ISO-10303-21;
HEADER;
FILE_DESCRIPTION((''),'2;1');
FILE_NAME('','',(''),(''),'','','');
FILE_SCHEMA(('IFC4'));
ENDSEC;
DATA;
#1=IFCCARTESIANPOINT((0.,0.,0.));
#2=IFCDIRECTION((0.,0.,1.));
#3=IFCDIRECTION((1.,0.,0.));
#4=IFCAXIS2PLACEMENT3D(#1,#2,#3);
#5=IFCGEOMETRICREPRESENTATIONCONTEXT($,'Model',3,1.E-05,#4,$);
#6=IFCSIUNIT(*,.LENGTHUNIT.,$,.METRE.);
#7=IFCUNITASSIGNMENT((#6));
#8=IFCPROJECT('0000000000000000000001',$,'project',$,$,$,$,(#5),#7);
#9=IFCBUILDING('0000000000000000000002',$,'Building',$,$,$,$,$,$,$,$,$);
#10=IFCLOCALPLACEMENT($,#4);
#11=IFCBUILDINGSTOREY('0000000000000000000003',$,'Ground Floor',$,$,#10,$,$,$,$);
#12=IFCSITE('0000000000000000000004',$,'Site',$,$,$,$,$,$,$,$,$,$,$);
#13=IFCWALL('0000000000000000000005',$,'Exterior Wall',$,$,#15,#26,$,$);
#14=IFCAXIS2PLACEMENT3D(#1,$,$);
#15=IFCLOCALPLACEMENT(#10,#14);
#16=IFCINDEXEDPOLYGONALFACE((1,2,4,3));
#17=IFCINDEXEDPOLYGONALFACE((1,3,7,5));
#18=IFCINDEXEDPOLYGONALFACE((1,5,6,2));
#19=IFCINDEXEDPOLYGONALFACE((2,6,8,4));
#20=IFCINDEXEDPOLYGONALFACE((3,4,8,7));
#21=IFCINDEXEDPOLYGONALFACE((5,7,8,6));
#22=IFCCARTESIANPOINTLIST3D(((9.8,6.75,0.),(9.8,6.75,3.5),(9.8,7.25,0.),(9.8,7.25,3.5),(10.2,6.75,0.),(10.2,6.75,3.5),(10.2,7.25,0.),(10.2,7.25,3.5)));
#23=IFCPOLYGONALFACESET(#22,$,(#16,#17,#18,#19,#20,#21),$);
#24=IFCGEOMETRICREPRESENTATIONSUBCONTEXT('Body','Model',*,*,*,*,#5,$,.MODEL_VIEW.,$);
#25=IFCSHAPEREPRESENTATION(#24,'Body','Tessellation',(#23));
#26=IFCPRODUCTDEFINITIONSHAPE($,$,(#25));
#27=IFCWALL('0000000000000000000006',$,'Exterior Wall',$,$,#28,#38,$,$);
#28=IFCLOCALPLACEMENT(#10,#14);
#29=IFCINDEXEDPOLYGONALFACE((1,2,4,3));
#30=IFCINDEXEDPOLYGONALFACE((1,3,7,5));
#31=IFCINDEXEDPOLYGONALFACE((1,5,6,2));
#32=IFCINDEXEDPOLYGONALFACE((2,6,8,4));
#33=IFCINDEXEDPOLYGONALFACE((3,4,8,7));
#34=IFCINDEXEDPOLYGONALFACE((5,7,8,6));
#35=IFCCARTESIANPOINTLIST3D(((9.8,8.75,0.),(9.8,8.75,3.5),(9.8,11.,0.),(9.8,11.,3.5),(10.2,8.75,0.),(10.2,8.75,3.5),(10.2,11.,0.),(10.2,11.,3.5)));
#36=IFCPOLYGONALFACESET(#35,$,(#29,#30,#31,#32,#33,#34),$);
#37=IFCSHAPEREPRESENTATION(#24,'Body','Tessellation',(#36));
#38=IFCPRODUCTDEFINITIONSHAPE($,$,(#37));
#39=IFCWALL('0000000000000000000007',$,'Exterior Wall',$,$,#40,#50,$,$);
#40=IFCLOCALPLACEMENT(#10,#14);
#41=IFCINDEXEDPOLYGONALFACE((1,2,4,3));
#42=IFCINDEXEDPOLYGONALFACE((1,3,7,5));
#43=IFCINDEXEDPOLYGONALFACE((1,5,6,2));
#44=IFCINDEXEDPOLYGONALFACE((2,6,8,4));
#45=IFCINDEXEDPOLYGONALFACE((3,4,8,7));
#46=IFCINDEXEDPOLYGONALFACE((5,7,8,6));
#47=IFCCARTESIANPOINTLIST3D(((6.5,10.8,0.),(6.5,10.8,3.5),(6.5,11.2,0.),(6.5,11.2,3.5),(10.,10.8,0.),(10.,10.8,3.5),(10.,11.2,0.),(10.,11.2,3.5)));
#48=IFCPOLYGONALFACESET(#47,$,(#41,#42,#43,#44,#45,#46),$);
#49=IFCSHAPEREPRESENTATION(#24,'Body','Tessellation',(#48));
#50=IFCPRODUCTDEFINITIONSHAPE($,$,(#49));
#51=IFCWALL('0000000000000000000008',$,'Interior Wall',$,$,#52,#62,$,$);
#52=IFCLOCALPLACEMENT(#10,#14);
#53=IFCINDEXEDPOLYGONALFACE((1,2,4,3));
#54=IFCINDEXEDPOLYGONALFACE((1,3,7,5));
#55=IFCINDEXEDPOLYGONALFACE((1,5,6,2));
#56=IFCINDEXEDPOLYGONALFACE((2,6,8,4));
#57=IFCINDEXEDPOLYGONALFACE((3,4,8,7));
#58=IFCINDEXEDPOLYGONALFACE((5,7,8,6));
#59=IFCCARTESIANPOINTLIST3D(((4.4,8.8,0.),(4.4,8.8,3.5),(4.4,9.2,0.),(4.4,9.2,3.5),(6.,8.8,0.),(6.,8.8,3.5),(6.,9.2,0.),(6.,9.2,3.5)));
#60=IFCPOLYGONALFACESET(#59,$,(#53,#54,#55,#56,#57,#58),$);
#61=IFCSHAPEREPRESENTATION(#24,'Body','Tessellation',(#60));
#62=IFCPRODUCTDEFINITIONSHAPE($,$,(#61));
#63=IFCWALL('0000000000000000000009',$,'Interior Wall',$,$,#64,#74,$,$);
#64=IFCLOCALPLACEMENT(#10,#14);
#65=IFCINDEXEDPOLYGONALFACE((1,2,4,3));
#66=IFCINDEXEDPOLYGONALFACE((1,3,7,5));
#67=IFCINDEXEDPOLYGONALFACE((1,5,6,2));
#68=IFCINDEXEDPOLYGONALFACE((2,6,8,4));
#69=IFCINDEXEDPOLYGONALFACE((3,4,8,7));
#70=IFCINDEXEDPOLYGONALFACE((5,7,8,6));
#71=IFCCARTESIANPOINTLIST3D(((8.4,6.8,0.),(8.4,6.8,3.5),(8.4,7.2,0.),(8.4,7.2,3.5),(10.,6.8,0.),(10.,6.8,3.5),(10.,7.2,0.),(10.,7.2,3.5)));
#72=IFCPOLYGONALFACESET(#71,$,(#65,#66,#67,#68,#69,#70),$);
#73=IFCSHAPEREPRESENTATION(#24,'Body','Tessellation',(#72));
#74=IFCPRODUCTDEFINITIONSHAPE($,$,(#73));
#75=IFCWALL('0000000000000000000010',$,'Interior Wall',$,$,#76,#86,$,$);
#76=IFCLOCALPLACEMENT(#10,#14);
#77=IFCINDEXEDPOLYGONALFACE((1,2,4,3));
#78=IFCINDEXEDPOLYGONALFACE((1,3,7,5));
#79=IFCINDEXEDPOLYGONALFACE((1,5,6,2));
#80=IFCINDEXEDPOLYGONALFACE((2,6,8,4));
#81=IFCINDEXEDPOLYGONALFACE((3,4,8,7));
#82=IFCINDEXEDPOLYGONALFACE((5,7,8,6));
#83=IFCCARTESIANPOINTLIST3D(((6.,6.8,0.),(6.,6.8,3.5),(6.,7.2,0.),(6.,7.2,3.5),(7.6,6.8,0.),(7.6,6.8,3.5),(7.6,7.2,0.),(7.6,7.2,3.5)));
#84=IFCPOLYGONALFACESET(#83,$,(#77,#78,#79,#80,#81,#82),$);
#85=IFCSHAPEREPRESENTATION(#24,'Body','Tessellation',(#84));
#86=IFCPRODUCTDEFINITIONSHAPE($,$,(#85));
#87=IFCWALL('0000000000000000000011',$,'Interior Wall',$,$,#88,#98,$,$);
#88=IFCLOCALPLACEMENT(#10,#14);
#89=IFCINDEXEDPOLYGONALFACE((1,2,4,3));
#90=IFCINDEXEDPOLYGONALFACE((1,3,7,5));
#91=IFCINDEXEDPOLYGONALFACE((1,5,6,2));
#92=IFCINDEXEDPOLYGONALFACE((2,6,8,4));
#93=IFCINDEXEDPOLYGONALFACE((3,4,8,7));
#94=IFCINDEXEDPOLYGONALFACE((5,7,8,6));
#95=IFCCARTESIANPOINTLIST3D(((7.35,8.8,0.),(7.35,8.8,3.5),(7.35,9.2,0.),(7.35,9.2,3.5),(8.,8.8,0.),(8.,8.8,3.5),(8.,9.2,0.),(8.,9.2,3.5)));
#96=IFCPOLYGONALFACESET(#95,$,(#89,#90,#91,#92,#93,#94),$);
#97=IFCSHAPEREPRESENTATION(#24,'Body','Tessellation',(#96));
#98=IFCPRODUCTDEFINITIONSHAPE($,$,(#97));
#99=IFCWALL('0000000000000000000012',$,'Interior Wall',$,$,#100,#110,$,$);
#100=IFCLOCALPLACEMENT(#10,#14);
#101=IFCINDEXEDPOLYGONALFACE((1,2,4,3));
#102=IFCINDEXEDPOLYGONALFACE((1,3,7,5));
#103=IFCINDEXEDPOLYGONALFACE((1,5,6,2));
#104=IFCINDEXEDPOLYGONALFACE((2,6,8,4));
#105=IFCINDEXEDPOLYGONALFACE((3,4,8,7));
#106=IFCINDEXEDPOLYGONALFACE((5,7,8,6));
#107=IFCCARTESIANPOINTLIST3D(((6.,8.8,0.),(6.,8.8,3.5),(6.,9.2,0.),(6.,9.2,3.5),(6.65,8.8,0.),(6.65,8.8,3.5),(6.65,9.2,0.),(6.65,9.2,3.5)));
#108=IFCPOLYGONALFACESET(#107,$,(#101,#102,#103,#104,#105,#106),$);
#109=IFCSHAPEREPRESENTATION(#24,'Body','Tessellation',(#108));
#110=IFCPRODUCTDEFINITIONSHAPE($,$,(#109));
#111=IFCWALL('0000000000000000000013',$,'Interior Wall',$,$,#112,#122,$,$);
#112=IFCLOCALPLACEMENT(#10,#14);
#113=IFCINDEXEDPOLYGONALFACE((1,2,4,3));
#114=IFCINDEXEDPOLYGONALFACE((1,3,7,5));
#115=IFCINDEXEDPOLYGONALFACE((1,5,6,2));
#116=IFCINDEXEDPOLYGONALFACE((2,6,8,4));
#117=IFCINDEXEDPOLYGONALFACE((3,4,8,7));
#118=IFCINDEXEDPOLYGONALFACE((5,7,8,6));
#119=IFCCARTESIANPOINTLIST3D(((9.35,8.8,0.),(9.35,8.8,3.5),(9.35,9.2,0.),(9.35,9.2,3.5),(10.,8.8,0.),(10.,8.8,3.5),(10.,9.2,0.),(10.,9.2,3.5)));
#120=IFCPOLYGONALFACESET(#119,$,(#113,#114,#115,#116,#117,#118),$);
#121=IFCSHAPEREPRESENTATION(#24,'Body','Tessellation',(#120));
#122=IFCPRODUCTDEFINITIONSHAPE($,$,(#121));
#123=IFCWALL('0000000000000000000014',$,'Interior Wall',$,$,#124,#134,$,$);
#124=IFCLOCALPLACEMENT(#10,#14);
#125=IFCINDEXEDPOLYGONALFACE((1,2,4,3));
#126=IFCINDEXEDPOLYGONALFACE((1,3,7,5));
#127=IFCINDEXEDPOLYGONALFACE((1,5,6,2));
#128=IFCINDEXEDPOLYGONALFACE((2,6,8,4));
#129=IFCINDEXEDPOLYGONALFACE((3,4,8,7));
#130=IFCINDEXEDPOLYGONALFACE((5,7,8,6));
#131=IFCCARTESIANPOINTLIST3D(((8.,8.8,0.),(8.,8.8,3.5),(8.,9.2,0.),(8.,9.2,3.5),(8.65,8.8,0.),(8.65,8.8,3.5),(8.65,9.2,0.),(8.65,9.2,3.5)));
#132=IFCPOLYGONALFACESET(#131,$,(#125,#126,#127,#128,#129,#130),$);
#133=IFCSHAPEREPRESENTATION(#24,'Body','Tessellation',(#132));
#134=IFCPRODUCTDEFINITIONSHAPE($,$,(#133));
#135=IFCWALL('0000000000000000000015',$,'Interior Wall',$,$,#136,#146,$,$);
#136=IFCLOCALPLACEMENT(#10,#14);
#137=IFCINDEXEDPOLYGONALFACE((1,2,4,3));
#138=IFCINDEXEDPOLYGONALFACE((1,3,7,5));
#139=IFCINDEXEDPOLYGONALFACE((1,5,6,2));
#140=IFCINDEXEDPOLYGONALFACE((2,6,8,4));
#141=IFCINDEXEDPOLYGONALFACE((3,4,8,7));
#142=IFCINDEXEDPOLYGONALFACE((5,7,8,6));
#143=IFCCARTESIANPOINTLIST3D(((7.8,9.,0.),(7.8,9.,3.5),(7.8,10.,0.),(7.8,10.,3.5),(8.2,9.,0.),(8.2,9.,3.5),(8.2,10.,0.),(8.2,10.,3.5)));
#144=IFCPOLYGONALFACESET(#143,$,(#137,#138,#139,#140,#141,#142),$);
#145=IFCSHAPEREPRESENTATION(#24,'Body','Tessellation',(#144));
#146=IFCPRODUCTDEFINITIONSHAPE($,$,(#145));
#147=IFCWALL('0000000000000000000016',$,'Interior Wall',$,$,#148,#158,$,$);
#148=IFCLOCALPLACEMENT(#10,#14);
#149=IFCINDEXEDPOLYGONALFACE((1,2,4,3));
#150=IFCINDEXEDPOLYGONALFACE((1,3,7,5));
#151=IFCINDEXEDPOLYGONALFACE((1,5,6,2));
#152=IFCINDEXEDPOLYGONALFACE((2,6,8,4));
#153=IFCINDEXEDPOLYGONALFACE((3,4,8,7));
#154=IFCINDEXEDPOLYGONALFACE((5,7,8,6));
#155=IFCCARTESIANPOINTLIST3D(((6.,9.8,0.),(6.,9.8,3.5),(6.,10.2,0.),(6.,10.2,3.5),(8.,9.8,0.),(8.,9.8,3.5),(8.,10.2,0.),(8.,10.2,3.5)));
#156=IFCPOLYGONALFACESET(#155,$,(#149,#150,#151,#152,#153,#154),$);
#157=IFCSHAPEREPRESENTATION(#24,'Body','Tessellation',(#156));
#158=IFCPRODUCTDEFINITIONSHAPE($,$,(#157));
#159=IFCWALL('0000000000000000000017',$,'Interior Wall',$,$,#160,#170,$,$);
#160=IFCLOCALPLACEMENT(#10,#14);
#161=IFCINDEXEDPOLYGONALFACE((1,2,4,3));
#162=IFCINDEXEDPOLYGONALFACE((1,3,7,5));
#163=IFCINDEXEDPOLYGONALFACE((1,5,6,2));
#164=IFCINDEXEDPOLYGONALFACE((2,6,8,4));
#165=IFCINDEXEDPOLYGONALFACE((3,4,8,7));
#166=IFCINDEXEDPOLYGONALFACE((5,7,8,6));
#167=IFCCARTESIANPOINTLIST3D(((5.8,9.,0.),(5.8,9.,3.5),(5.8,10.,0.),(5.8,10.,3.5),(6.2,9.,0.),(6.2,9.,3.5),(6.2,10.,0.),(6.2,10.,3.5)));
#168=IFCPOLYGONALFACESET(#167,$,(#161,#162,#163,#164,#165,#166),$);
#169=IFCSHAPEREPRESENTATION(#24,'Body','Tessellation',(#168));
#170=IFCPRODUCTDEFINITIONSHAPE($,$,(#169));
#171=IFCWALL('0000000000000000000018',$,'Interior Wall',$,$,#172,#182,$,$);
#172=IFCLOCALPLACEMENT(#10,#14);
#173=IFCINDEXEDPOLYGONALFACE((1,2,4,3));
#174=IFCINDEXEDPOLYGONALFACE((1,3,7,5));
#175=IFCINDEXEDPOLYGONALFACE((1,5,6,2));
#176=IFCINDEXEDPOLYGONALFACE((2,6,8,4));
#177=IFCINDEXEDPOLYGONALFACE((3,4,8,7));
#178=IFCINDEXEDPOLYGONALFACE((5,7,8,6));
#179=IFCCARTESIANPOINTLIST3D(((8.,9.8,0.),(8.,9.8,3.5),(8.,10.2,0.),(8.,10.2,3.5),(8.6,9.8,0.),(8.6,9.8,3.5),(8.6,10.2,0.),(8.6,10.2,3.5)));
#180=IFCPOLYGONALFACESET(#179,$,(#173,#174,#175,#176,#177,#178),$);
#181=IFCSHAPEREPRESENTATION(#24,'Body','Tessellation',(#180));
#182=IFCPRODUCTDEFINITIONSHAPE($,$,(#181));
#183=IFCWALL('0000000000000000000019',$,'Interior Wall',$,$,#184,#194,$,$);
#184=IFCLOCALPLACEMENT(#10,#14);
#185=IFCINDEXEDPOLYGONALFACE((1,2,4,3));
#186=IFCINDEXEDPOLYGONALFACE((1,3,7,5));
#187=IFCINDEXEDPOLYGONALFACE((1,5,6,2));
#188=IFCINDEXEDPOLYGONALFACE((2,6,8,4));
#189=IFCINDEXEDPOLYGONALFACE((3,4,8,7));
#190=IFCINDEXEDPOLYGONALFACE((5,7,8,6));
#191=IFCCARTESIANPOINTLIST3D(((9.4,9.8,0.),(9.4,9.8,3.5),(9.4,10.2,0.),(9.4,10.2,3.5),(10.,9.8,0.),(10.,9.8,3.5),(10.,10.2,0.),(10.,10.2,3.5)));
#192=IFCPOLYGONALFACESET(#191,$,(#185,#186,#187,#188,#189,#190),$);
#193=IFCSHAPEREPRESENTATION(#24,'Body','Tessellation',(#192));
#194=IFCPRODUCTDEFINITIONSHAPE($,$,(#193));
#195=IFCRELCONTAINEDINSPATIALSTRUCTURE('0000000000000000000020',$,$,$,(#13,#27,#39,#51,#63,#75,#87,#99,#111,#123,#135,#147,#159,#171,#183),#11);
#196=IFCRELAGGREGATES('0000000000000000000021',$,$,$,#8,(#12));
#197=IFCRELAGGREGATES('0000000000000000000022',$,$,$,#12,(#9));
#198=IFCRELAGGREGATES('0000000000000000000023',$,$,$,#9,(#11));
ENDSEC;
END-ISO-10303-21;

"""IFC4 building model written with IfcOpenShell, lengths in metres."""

from ifc_helpers import new_model, si_unit, frame, origin_with_axes, place, context, subcontext, project, spatial, indexed_curve, outline, extrude, element, save


model = new_model("IFC4")

# Units and contexts
model_context = context("Model", 3, precision=1e-05, world=origin_with_axes())
body_context = subcontext(model_context, "Body", "Model", "MODEL_VIEW")
ifc_project = project(units=[si_unit("LENGTHUNIT", "METRE")], contexts=[model_context])

# Site, building, storey
site = spatial("IfcSite", under=ifc_project, Name="Site")
building = spatial("IfcBuilding", under=site, Name="Building")
storey_placement = place(None, origin_with_axes())
storey = spatial("IfcBuildingStorey", under=building, at=storey_placement, Name="Ground Floor")

# Walls
wall_1_placement = place(storey_placement, frame((10.0, 6.75, 0.0), z_axis=(0.0, 0.0, 1.0), x_axis=(0.0, 1.0, 0.0)))
element("IfcWall", 1, at=wall_1_placement, inside=storey, Name="Exterior Wall", context=body_context, shape_type="SweptSolid", body=[
    extrude(outline(indexed_curve([(0.0, 0.0), (0.0, 0.4), (0.5, 0.4), (0.5, 0.0), (0.0, 0.0)], self_intersect=False)), frame((0.0, -0.2, 0.0), z_axis=(0.0, 0.0, 1.0), x_axis=(1.0, 0.0, 0.0)), (0.0, 0.0, 1.0), 3.5),
])
wall_2_placement = place(storey_placement, frame((10.0, 8.75, 0.0), z_axis=(0.0, 0.0, 1.0), x_axis=(0.0, 1.0, 0.0)))
element("IfcWall", 2, at=wall_2_placement, inside=storey, Name="Exterior Wall", context=body_context, shape_type="SweptSolid", body=[
    extrude(outline(indexed_curve([(0.0, 0.0), (0.0, 0.4), (2.25, 0.4), (2.25, 0.0), (0.0, 0.0)], self_intersect=False)), frame((0.0, -0.2, 0.0), z_axis=(0.0, 0.0, 1.0), x_axis=(1.0, 0.0, 0.0)), (0.0, 0.0, 1.0), 3.5),
])
wall_3_placement = place(storey_placement, frame((10.0, 11.0, 0.0), z_axis=(0.0, 0.0, 1.0), x_axis=(-1.0, 0.0, 0.0)))
element("IfcWall", 3, at=wall_3_placement, inside=storey, Name="Exterior Wall", context=body_context, shape_type="SweptSolid", body=[
    extrude(outline(indexed_curve([(0.0, 0.0), (0.0, 0.4), (3.5, 0.4), (3.5, 0.0), (0.0, 0.0)], self_intersect=False)), frame((0.0, -0.2, 0.0), z_axis=(0.0, 0.0, 1.0), x_axis=(1.0, 0.0, 0.0)), (0.0, 0.0, 1.0), 3.5),
])
for number, where, z_axis, x_axis, name in (
    (4, (6.0, 9.0, 0.0), (0.0, 0.0, 1.0), (-1.0, 0.0, 0.0), "Interior Wall"),
    (5, (10.0, 7.0, 0.0), (0.0, 0.0, 1.0), (-1.0, 0.0, 0.0), "Interior Wall"),
    (6, (7.6, 7.0, 0.0), (0.0, 0.0, 1.0), (-1.0, 0.0, 0.0), "Interior Wall"),
):
    element("IfcWall", number, at=place(storey_placement, frame(where, z_axis=z_axis, x_axis=x_axis)), inside=storey, Name=name, context=body_context, shape_type="SweptSolid", body=[
        extrude(outline(indexed_curve([(0.0, 0.0), (0.0, 0.4), (1.6, 0.4), (1.6, 0.0), (0.0, 0.0)], self_intersect=False)), frame((0.0, -0.2, 0.0), z_axis=(0.0, 0.0, 1.0), x_axis=(1.0, 0.0, 0.0)), (0.0, 0.0, 1.0), 3.5),
    ])
for number, where, z_axis, x_axis, name in (
    (7, (8.0, 9.0, 0.0), (0.0, 0.0, 1.0), (-1.0, 0.0, 0.0), "Interior Wall"),
    (8, (6.65, 9.0, 0.0), (0.0, 0.0, 1.0), (-1.0, 0.0, 0.0), "Interior Wall"),
    (9, (10.0, 9.0, 0.0), (0.0, 0.0, 1.0), (-1.0, 0.0, 0.0), "Interior Wall"),
    (10, (8.65, 9.0, 0.0), (0.0, 0.0, 1.0), (-1.0, 0.0, 0.0), "Interior Wall"),
):
    element("IfcWall", number, at=place(storey_placement, frame(where, z_axis=z_axis, x_axis=x_axis)), inside=storey, Name=name, context=body_context, shape_type="SweptSolid", body=[
        extrude(outline(indexed_curve([(0.0, 0.0), (0.0, 0.4), (0.65, 0.4), (0.65, 0.0), (0.0, 0.0)], self_intersect=False)), frame((0.0, -0.2, 0.0), z_axis=(0.0, 0.0, 1.0), x_axis=(1.0, 0.0, 0.0)), (0.0, 0.0, 1.0), 3.5),
    ])
wall_4_placement = place(storey_placement, frame((8.0, 9.0, 0.0), z_axis=(0.0, 0.0, 1.0), x_axis=(0.0, 1.0, 0.0)))
element("IfcWall", 11, at=wall_4_placement, inside=storey, Name="Interior Wall", context=body_context, shape_type="SweptSolid", body=[
    extrude(outline(indexed_curve([(0.0, 0.0), (0.0, 0.4), (1.0, 0.4), (1.0, 0.0), (0.0, 0.0)], self_intersect=False)), frame((0.0, -0.2, 0.0), z_axis=(0.0, 0.0, 1.0), x_axis=(1.0, 0.0, 0.0)), (0.0, 0.0, 1.0), 3.5),
])
wall_5_placement = place(storey_placement, frame((8.0, 10.0, 0.0), z_axis=(0.0, 0.0, 1.0), x_axis=(-1.0, 0.0, 0.0)))
element("IfcWall", 12, at=wall_5_placement, inside=storey, Name="Interior Wall", context=body_context, shape_type="SweptSolid", body=[
    extrude(outline(indexed_curve([(0.0, 0.0), (0.0, 0.4), (2.0, 0.4), (2.0, 0.0), (0.0, 0.0)], self_intersect=False)), frame((0.0, -0.2, 0.0), z_axis=(0.0, 0.0, 1.0), x_axis=(1.0, 0.0, 0.0)), (0.0, 0.0, 1.0), 3.5),
])
wall_6_placement = place(storey_placement, frame((6.0, 10.0, 0.0), z_axis=(0.0, 0.0, 1.0), x_axis=(0.0, -1.0, 0.0)))
element("IfcWall", 13, at=wall_6_placement, inside=storey, Name="Interior Wall", context=body_context, shape_type="SweptSolid", body=[
    extrude(outline(indexed_curve([(0.0, 0.0), (0.0, 0.4), (1.0, 0.4), (1.0, 0.0), (0.0, 0.0)], self_intersect=False)), frame((0.0, -0.2, 0.0), z_axis=(0.0, 0.0, 1.0), x_axis=(1.0, 0.0, 0.0)), (0.0, 0.0, 1.0), 3.5),
])
for number, where, z_axis, x_axis, name in (
    (14, (8.0, 10.0, 0.0), (0.0, 0.0, 1.0), (1.0, 0.0, 0.0), "Interior Wall"),
    (15, (9.4, 10.0, 0.0), (0.0, 0.0, 1.0), (1.0, 0.0, 0.0), "Interior Wall"),
):
    element("IfcWall", number, at=place(storey_placement, frame(where, z_axis=z_axis, x_axis=x_axis)), inside=storey, Name=name, context=body_context, shape_type="SweptSolid", body=[
        extrude(outline(indexed_curve([(0.0, 0.0), (0.0, 0.4), (0.6, 0.4), (0.6, 0.0), (0.0, 0.0)], self_intersect=False)), frame((0.0, -0.2, 0.0), z_axis=(0.0, 0.0, 1.0), x_axis=(1.0, 0.0, 0.0)), (0.0, 0.0, 1.0), 3.5),
    ])

save(model, "model.ifc")
